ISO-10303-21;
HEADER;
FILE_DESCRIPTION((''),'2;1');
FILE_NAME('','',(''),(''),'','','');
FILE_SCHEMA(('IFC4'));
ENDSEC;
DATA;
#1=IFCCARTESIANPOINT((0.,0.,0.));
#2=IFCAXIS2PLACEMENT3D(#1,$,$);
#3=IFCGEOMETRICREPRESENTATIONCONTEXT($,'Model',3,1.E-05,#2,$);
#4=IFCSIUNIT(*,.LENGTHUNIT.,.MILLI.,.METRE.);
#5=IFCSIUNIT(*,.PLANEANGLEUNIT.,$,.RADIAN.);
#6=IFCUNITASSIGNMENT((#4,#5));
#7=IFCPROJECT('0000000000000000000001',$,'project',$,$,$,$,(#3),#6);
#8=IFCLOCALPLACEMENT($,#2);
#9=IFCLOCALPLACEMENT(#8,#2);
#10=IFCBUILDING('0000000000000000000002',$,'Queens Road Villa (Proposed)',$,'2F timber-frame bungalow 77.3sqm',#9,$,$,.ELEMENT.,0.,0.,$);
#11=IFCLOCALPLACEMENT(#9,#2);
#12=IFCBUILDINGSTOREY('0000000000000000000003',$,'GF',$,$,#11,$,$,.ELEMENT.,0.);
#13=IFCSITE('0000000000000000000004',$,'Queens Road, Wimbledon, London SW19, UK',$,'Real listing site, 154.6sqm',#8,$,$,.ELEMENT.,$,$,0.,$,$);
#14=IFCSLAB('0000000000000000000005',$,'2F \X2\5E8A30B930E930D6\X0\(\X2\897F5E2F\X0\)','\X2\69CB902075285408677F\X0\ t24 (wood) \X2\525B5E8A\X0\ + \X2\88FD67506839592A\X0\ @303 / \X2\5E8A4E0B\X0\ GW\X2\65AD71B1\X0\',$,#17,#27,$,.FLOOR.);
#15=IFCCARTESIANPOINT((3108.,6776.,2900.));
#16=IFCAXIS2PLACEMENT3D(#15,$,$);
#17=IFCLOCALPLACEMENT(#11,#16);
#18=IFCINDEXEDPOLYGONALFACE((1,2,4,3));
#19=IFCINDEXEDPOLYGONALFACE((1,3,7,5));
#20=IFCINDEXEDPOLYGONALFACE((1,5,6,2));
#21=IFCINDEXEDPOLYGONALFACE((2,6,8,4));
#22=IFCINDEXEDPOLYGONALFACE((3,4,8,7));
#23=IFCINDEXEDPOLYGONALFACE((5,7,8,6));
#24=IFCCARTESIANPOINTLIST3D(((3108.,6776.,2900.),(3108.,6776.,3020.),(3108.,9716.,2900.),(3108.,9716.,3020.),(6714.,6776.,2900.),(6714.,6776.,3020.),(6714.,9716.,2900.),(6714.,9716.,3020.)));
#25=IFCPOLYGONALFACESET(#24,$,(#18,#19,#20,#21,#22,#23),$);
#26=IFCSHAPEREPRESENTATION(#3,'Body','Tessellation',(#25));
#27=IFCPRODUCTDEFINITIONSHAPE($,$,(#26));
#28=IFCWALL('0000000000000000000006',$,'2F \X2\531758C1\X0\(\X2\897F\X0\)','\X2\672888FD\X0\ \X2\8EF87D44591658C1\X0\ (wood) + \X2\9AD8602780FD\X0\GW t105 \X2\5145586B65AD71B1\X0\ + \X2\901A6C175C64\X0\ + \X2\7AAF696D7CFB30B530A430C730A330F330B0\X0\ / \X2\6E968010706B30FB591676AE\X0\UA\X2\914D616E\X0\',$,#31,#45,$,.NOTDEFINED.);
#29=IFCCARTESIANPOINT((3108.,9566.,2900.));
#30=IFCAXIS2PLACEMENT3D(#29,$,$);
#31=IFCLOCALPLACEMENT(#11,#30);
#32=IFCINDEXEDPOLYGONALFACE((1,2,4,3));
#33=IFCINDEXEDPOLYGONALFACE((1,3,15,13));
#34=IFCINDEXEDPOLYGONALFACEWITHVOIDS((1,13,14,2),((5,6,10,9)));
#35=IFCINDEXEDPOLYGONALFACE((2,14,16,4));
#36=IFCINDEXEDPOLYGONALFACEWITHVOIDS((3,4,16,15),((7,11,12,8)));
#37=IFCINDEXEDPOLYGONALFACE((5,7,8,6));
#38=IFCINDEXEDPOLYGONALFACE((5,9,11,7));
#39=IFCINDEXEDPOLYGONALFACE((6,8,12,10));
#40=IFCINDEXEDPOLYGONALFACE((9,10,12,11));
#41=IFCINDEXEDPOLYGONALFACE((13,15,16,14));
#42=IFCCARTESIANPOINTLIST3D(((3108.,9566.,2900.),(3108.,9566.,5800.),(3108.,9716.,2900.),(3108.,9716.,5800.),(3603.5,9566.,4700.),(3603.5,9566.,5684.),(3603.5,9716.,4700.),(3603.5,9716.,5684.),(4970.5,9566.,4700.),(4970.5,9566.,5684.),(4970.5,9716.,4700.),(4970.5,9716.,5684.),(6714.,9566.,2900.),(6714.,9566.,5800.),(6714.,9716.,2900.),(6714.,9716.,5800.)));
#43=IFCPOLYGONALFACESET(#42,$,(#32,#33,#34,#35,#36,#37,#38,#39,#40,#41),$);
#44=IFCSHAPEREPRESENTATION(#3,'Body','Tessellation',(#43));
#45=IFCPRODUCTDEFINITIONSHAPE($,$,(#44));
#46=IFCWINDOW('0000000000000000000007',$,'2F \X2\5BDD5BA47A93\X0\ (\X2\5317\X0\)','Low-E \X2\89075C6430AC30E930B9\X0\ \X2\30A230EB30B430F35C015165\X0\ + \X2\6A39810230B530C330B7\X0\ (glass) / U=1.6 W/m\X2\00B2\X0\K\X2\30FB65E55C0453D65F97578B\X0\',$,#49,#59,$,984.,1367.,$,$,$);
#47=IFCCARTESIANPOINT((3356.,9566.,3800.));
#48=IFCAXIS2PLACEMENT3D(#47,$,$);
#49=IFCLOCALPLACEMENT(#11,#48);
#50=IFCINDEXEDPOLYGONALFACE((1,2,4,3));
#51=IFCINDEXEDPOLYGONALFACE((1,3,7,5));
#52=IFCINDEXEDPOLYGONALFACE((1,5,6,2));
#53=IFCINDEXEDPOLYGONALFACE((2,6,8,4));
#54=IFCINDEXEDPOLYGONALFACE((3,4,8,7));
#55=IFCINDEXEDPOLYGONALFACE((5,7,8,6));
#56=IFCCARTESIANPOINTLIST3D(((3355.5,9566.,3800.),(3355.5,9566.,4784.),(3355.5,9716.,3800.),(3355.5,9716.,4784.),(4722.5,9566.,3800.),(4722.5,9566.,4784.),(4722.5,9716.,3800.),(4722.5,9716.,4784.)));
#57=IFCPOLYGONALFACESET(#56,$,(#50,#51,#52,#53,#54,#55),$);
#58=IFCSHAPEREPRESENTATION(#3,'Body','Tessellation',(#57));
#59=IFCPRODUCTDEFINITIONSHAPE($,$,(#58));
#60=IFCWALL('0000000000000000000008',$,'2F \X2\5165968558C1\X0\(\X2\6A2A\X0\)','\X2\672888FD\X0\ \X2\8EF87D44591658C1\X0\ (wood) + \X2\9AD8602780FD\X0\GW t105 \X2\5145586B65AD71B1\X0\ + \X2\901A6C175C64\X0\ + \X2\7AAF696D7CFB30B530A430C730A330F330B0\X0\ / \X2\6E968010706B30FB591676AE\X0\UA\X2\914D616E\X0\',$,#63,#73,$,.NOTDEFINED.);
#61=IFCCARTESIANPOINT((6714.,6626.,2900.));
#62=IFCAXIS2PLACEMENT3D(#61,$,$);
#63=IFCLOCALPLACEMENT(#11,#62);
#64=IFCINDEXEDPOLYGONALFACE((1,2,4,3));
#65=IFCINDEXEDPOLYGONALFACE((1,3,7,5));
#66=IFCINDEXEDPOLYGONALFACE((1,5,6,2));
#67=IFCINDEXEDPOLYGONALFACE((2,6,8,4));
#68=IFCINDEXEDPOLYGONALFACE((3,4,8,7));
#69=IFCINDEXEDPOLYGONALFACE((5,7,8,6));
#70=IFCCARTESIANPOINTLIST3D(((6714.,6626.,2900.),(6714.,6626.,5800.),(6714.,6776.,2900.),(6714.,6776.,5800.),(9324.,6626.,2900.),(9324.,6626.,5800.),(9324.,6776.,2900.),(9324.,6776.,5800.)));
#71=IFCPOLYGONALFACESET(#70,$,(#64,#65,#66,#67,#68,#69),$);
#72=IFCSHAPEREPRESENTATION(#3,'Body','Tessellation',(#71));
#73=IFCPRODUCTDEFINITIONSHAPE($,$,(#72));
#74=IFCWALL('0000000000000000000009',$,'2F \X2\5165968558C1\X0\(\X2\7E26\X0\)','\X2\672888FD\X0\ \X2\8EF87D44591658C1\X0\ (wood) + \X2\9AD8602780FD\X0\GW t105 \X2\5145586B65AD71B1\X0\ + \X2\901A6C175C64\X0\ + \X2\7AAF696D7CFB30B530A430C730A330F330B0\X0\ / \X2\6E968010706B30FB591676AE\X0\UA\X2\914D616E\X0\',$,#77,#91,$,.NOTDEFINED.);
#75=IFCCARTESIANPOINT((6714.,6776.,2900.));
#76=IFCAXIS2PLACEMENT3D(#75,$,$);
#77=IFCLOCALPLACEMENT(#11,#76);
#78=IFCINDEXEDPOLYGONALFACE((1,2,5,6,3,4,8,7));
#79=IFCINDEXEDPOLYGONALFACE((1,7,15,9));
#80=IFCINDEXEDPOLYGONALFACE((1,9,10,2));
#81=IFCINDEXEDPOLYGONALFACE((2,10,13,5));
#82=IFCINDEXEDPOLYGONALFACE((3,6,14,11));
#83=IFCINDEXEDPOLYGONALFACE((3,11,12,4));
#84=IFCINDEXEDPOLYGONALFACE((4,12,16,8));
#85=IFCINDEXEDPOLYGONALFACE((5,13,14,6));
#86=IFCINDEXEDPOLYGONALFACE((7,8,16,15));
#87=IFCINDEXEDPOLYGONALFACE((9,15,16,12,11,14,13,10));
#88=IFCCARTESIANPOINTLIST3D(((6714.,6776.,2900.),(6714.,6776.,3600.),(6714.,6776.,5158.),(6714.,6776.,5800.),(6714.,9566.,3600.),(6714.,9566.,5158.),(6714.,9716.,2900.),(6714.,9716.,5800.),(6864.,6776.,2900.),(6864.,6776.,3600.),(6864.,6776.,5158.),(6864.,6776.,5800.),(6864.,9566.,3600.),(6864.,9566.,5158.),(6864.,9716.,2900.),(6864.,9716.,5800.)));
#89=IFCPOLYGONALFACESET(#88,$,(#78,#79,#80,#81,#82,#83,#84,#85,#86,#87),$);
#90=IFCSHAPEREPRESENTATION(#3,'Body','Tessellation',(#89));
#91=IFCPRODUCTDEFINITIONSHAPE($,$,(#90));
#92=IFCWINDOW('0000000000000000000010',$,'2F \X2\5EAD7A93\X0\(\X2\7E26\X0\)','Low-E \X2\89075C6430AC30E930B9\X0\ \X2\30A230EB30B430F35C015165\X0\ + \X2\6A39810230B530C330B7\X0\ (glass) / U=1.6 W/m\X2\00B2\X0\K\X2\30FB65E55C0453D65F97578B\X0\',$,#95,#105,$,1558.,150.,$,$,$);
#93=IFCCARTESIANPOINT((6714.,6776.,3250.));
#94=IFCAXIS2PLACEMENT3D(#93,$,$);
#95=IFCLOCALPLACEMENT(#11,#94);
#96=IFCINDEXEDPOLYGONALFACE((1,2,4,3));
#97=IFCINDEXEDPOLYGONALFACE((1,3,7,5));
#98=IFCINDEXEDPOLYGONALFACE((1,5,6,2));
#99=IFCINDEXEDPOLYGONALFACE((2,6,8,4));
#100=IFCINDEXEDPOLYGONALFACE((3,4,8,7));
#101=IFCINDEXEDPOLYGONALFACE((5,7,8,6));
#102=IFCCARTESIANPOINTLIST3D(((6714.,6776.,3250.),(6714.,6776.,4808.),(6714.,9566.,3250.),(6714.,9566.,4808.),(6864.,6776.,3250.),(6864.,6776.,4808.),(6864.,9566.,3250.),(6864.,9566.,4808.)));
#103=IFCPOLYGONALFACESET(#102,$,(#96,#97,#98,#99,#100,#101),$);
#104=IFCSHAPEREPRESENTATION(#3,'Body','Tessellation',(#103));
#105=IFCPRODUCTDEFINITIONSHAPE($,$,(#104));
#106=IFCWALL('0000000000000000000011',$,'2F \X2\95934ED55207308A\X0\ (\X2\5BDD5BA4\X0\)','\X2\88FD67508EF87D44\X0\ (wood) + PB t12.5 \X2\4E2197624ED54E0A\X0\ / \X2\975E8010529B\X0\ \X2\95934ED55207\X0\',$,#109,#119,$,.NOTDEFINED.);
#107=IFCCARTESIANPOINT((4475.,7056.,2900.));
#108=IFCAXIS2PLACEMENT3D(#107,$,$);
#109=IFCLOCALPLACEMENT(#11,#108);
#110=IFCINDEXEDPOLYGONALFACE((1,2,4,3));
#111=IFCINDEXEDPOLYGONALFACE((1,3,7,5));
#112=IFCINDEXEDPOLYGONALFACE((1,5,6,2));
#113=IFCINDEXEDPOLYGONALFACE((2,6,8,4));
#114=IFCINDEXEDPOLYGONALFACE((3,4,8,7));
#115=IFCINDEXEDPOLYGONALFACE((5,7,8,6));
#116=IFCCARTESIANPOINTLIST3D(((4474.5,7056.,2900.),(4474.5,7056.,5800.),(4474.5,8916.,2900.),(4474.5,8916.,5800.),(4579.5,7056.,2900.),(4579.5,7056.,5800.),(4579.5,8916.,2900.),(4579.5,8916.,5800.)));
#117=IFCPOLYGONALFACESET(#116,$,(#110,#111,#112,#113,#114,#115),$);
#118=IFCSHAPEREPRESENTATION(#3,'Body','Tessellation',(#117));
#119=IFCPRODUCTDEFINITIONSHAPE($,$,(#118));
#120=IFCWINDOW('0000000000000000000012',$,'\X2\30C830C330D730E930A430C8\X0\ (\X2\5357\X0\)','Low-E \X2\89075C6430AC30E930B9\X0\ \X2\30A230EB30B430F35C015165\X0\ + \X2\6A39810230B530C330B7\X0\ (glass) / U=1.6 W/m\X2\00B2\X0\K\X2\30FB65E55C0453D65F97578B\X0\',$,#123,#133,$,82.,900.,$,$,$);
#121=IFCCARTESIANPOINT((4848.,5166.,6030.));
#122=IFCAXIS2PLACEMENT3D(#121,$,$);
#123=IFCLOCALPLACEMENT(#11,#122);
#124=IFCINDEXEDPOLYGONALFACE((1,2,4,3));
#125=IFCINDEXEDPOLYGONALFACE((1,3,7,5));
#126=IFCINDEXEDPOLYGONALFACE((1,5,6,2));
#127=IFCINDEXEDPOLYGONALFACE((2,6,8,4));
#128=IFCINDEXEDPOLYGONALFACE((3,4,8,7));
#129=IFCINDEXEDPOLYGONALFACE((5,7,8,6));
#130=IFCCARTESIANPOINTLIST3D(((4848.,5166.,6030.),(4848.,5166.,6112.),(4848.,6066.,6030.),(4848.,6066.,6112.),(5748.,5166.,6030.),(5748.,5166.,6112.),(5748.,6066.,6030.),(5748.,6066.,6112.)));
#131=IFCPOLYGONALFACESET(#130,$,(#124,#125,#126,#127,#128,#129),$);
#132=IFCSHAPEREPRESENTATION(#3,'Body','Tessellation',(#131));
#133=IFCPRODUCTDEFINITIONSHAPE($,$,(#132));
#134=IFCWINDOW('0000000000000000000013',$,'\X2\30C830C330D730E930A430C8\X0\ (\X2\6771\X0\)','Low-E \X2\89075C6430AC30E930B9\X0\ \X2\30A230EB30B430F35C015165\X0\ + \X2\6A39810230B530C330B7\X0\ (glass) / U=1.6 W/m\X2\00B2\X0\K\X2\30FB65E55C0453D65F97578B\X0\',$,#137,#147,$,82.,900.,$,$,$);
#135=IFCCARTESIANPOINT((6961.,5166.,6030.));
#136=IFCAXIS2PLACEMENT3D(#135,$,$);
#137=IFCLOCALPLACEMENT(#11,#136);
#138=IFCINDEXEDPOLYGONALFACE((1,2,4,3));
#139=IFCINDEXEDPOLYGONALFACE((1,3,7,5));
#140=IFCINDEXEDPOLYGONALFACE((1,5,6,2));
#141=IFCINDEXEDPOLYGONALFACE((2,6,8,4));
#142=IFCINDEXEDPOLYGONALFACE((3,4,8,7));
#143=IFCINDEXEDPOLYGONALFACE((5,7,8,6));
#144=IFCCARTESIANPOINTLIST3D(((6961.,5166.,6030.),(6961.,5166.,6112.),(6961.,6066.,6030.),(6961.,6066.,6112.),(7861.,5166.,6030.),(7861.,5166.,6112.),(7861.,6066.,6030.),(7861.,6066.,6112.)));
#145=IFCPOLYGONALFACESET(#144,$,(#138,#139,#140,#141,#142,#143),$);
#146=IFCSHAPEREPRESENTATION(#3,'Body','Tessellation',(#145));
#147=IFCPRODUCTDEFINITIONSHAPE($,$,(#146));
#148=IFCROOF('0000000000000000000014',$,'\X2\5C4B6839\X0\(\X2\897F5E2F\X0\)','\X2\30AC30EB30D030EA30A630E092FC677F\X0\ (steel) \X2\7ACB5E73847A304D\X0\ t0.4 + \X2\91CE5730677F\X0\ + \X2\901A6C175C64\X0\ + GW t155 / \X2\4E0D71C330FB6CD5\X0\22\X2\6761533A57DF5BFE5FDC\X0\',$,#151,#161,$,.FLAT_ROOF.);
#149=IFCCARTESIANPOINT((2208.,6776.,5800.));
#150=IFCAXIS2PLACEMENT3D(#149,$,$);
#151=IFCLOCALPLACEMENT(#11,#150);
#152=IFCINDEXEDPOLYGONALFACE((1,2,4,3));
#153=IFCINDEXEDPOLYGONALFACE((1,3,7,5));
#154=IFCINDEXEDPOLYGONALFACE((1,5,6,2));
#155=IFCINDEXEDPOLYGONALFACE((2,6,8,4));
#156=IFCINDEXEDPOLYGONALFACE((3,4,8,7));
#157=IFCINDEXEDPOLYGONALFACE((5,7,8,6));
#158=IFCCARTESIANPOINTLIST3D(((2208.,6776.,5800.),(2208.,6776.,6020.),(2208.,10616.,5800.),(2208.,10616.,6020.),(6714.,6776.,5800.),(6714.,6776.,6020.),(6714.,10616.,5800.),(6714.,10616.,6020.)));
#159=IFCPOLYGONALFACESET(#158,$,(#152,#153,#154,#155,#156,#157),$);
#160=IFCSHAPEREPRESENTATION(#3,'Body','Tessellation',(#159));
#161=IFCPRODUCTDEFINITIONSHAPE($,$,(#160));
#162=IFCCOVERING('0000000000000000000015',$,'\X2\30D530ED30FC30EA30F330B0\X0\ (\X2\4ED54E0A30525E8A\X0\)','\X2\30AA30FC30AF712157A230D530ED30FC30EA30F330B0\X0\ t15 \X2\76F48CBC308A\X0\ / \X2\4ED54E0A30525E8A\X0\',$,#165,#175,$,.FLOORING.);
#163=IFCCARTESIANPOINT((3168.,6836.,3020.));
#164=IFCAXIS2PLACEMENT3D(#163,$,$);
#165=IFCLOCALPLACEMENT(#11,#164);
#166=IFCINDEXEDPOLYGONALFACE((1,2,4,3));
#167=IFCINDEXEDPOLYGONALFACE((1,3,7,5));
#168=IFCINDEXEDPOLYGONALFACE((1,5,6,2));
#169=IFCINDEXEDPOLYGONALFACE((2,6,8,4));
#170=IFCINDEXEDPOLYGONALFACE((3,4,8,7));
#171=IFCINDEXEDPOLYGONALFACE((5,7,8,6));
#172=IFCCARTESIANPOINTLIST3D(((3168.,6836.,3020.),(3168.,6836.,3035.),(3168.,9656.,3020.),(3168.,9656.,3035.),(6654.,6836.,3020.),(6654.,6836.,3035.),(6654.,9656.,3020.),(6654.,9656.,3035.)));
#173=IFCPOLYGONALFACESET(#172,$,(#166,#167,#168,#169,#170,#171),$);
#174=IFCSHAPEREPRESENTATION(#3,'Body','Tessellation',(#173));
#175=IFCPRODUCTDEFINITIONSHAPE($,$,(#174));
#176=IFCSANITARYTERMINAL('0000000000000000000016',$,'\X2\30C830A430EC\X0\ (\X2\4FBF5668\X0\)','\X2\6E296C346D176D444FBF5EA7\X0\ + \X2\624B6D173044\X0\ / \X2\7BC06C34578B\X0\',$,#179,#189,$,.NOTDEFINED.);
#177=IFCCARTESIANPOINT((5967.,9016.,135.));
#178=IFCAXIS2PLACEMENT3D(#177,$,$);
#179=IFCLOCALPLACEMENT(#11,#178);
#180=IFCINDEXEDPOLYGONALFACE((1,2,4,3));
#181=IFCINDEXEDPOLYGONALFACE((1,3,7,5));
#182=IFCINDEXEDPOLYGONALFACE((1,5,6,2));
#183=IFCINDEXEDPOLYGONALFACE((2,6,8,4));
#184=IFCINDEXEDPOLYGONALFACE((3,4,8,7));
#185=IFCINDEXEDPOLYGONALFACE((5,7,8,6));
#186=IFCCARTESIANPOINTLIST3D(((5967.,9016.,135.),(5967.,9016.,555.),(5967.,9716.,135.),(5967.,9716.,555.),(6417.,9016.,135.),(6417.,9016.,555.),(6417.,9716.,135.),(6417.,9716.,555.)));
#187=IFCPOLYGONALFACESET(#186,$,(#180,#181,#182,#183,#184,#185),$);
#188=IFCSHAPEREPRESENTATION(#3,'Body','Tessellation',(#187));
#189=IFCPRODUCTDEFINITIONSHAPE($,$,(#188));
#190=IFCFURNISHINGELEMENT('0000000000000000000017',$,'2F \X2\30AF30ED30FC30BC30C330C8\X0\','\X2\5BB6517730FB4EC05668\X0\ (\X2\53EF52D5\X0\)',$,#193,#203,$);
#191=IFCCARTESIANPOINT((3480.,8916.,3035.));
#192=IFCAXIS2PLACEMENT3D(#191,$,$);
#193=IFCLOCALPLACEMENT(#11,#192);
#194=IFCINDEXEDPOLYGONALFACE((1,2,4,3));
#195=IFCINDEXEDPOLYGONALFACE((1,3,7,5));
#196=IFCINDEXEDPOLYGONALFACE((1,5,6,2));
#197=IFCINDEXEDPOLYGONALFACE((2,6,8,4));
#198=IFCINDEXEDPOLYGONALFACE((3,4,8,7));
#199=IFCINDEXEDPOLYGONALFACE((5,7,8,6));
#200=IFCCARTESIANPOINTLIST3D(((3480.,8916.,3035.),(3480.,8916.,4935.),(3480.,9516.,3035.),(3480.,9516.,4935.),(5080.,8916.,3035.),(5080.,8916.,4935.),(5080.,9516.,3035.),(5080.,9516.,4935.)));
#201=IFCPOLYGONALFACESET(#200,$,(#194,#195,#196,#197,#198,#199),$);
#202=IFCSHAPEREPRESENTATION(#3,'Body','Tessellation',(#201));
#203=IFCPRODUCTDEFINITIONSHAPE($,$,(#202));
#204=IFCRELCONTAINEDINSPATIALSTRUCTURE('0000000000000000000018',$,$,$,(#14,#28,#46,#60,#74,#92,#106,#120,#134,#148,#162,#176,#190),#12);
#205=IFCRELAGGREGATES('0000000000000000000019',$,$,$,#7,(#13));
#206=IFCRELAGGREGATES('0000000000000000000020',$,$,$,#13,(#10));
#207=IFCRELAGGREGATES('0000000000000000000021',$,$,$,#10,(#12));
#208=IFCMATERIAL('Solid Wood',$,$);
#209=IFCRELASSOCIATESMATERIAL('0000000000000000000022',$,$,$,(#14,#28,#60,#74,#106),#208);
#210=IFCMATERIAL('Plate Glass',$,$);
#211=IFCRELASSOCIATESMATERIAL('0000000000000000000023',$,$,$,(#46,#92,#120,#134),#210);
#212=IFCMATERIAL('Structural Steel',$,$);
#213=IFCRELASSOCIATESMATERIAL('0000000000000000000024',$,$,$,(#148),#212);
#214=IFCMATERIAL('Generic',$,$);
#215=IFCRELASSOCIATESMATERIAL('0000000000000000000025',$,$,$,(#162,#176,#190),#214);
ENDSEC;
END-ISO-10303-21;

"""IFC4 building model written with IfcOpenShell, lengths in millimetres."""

from ifc_helpers import new_model, si_unit, frame, frame_2d, origin, place, context, project, spatial, rectangle, extrude, material, element, fill, save


model = new_model("IFC4")

# Units and contexts
model_context = context("Model", 3, precision=1e-05, world=origin())
ifc_project = project(units=[si_unit("LENGTHUNIT", "METRE", prefix="MILLI"), si_unit("PLANEANGLEUNIT", "RADIAN")], contexts=[model_context])

# Site, building, storey
site_placement = place(None, origin())
site = spatial("IfcSite", under=ifc_project, at=site_placement, Name="Queens Road, Wimbledon, London SW19, UK", ObjectType="Real listing site, 154.6sqm", CompositionType="ELEMENT", RefElevation=0.0)
building_placement = place(site_placement, origin())
building = spatial("IfcBuilding", under=site, at=building_placement, Name="Queens Road Villa (Proposed)", ObjectType="2F timber-frame bungalow 77.3sqm", CompositionType="ELEMENT", ElevationOfRefHeight=0.0, ElevationOfTerrain=0.0)
storey_placement = place(building_placement, origin())
storey = spatial("IfcBuildingStorey", under=building, at=storey_placement, Name="GF", CompositionType="ELEMENT", Elevation=0.0)

# Slab
ifc_material_1 = material(Name="Solid Wood")
slab_placement = place(storey_placement, frame((3108.0, 6776.0, 2900.0)))
element("IfcSlab", 1, at=slab_placement, inside=storey, material=ifc_material_1, Name="2F 床スラブ(西帯)", Description="構造用合板 t24 (wood) 剛床 + 製材根太 @303 / 床下 GW断熱", PredefinedType="FLOOR", context=model_context, shape_type="SweptSolid", body=[
    extrude(rectangle(XDim=3606.0, YDim=2940.0, at=frame_2d((1803.0, 1470.0))), frame((3108.0, 6776.0, 2900.0)), (0.0, 0.0, 1.0), 120.0),
])

# Wall, opening, window
wall_1_placement = place(storey_placement, frame((3108.0, 9566.0, 2900.0)))
wall_1 = element("IfcWall", 2, at=wall_1_placement, inside=storey, material=ifc_material_1, Name="2F 北壁(西)", Description="木製 軸組外壁 (wood) + 高性能GW t105 充填断熱 + 通気層 + 窯業系サイディング / 準耐火・外皮UA配慮", PredefinedType="NOTDEFINED", context=model_context, shape_type="SweptSolid", body=[
    extrude(rectangle(XDim=3606.0, YDim=150.0, at=frame_2d((1803.0, 75.0))), frame((3108.0, 9566.0, 2900.0)), (0.0, 0.0, 1.0), 2900.0),
])
opening_1_placement = place(storey_placement, frame((3356.0, 9566.0, 3800.0)))
opening_1 = element("IfcOpeningElement", 3, at=opening_1_placement, cuts=wall_1, PredefinedType="NOTDEFINED", context=model_context, shape_type="SweptSolid", body=[
    extrude(rectangle(XDim=1367.0, YDim=150.0, at=frame_2d((683.0, 75.0))), frame((3356.0, 9566.0, 3800.0)), (0.0, 0.0, 1.0), 984.0),
])
ifc_material_2 = material(Name="Plate Glass")
window_1_placement = place(storey_placement, frame((3356.0, 9566.0, 3800.0)))
window_1 = element("IfcWindow", 4, at=window_1_placement, inside=storey, material=ifc_material_2, Name="2F 寝室窓 (北)", Description="Low-E 複層ガラス アルゴン封入 + 樹脂サッシ (glass) / U=1.6 W/m²K・日射取得型", OverallHeight=984.0, OverallWidth=1367.0, context=model_context, shape_type="SweptSolid", body=[
    extrude(rectangle(XDim=1367.0, YDim=150.0, at=frame_2d((683.0, 75.0))), frame((3356.0, 9566.0, 3800.0)), (0.0, 0.0, 1.0), 984.0),
])
fill(opening_1, window_1)

# Wall
wall_2_placement = place(storey_placement, frame((6714.0, 6626.0, 2900.0)))
element("IfcWall", 5, at=wall_2_placement, inside=storey, material=ifc_material_1, Name="2F 入隅壁(横)", Description="木製 軸組外壁 (wood) + 高性能GW t105 充填断熱 + 通気層 + 窯業系サイディング / 準耐火・外皮UA配慮", PredefinedType="NOTDEFINED", context=model_context, shape_type="SweptSolid", body=[
    extrude(rectangle(XDim=2610.0, YDim=150.0, at=frame_2d((1305.0, 75.0))), frame((6714.0, 6626.0, 2900.0)), (0.0, 0.0, 1.0), 2900.0),
])

# Wall, opening, window
wall_3_placement = place(storey_placement, frame((6714.0, 6776.0, 2900.0)))
wall_3 = element("IfcWall", 6, at=wall_3_placement, inside=storey, material=ifc_material_1, Name="2F 入隅壁(縦)", Description="木製 軸組外壁 (wood) + 高性能GW t105 充填断熱 + 通気層 + 窯業系サイディング / 準耐火・外皮UA配慮", PredefinedType="NOTDEFINED", context=model_context, shape_type="SweptSolid", body=[
    extrude(rectangle(XDim=150.0, YDim=2940.0, at=frame_2d((75.0, 1470.0))), frame((6714.0, 6776.0, 2900.0)), (0.0, 0.0, 1.0), 2900.0),
])
opening_2_placement = place(storey_placement, frame((6714.0, 6776.0, 3250.0)))
opening_2 = element("IfcOpeningElement", 7, at=opening_2_placement, cuts=wall_3, PredefinedType="NOTDEFINED", context=model_context, shape_type="SweptSolid", body=[
    extrude(rectangle(XDim=150.0, YDim=2790.0, at=frame_2d((75.0, 1395.0))), frame((6714.0, 6776.0, 3250.0)), (0.0, 0.0, 1.0), 1558.0),
])
window_2_placement = place(storey_placement, frame((6714.0, 6776.0, 3250.0)))
window_2 = element("IfcWindow", 8, at=window_2_placement, inside=storey, material=ifc_material_2, Name="2F 庭窓(縦)", Description="Low-E 複層ガラス アルゴン封入 + 樹脂サッシ (glass) / U=1.6 W/m²K・日射取得型", OverallHeight=1558.0, OverallWidth=150.0, context=model_context, shape_type="SweptSolid", body=[
    extrude(rectangle(XDim=150.0, YDim=2790.0, at=frame_2d((75.0, 1395.0))), frame((6714.0, 6776.0, 3250.0)), (0.0, 0.0, 1.0), 1558.0),
])
fill(opening_2, window_2)

# Wall
wall_4_placement = place(storey_placement, frame((4475.0, 7056.0, 2900.0)))
element("IfcWall", 9, at=wall_4_placement, inside=storey, material=ifc_material_1, Name="2F 間仕切り (寝室)", Description="製材軸組 (wood) + PB t12.5 両面仕上 / 非耐力 間仕切", PredefinedType="NOTDEFINED", context=model_context, shape_type="SweptSolid", body=[
    extrude(rectangle(XDim=105.0, YDim=1860.0, at=frame_2d((52.0, 930.0))), frame((4475.0, 7056.0, 2900.0)), (0.0, 0.0, 1.0), 2900.0),
])

# Windows
window_3_placement = place(storey_placement, frame((4848.0, 5166.0, 6030.0)))
element("IfcWindow", 10, at=window_3_placement, inside=storey, material=ifc_material_2, Name="トップライト (南)", Description="Low-E 複層ガラス アルゴン封入 + 樹脂サッシ (glass) / U=1.6 W/m²K・日射取得型", OverallHeight=82.0, OverallWidth=900.0, context=model_context, shape_type="SweptSolid", body=[
    extrude(rectangle(XDim=900.0, YDim=900.0, at=frame_2d((450.0, 450.0))), frame((4848.0, 5166.0, 6030.0)), (0.0, 0.0, 1.0), 82.0),
])
window_4_placement = place(storey_placement, frame((6961.0, 5166.0, 6030.0)))
element("IfcWindow", 11, at=window_4_placement, inside=storey, material=ifc_material_2, Name="トップライト (東)", Description="Low-E 複層ガラス アルゴン封入 + 樹脂サッシ (glass) / U=1.6 W/m²K・日射取得型", OverallHeight=82.0, OverallWidth=900.0, context=model_context, shape_type="SweptSolid", body=[
    extrude(rectangle(XDim=900.0, YDim=900.0, at=frame_2d((450.0, 450.0))), frame((6961.0, 5166.0, 6030.0)), (0.0, 0.0, 1.0), 82.0),
])

# Roof
ifc_material_3 = material(Name="Structural Steel")
for number, where, name in (
    (12, (2208.0, 6776.0, 5800.0), "屋根(西帯)"),
):
    element("IfcRoof", number, at=place(storey_placement, frame(where)), inside=storey, material=ifc_material_3, Name=name, Description="ガルバリウム鋼板 (steel) 立平葺き t0.4 + 野地板 + 通気層 + GW t155 / 不燃・法22条区域対応", PredefinedType="FLAT_ROOF", context=model_context, shape_type="SweptSolid", body=[
        extrude(rectangle(XDim=4506.0, YDim=3840.0, at=frame_2d((2253.0, 1920.0))), frame((2208.0, 6776.0, 5800.0)), (0.0, 0.0, 1.0), 220.0),
    ])

# Covering
ifc_material_4 = material(Name="Generic")
covering_placement = place(storey_placement, frame((3168.0, 6836.0, 3020.0)))
element("IfcCovering", 13, at=covering_placement, inside=storey, material=ifc_material_4, Name="フローリング (仕上げ床)", Description="オーク無垢フローリング t15 直貼り / 仕上げ床", PredefinedType="FLOORING", context=model_context, shape_type="SweptSolid", body=[
    extrude(rectangle(XDim=3486.0, YDim=2820.0, at=frame_2d((1743.0, 1410.0))), frame((3168.0, 6836.0, 3020.0)), (0.0, 0.0, 1.0), 15.0),
])

# Sanitary terminal
sanitary_terminal_placement = place(storey_placement, frame((5967.0, 9016.0, 135.0)))
element("IfcSanitaryTerminal", 14, at=sanitary_terminal_placement, inside=storey, material=ifc_material_4, Name="トイレ (便器)", Description="温水洗浄便座 + 手洗い / 節水型", PredefinedType="NOTDEFINED", context=model_context, shape_type="SweptSolid", body=[
    extrude(rectangle(XDim=450.0, YDim=700.0, at=frame_2d((225.0, 350.0))), frame((5967.0, 9016.0, 135.0)), (0.0, 0.0, 1.0), 420.0),
])

# Furnishing element
furnishing_1_placement = place(storey_placement, frame((3480.0, 8916.0, 3035.0)))
element("IfcFurnishingElement", 15, at=furnishing_1_placement, inside=storey, material=ifc_material_4, Name="2F クローゼット", Description="家具・什器 (可動)", context=model_context, shape_type="SweptSolid", body=[
    extrude(rectangle(XDim=1600.0, YDim=600.0, at=frame_2d((800.0, 300.0))), frame((3480.0, 8916.0, 3035.0)), (0.0, 0.0, 1.0), 1900.0),
])

save(model, "model.ifc")
